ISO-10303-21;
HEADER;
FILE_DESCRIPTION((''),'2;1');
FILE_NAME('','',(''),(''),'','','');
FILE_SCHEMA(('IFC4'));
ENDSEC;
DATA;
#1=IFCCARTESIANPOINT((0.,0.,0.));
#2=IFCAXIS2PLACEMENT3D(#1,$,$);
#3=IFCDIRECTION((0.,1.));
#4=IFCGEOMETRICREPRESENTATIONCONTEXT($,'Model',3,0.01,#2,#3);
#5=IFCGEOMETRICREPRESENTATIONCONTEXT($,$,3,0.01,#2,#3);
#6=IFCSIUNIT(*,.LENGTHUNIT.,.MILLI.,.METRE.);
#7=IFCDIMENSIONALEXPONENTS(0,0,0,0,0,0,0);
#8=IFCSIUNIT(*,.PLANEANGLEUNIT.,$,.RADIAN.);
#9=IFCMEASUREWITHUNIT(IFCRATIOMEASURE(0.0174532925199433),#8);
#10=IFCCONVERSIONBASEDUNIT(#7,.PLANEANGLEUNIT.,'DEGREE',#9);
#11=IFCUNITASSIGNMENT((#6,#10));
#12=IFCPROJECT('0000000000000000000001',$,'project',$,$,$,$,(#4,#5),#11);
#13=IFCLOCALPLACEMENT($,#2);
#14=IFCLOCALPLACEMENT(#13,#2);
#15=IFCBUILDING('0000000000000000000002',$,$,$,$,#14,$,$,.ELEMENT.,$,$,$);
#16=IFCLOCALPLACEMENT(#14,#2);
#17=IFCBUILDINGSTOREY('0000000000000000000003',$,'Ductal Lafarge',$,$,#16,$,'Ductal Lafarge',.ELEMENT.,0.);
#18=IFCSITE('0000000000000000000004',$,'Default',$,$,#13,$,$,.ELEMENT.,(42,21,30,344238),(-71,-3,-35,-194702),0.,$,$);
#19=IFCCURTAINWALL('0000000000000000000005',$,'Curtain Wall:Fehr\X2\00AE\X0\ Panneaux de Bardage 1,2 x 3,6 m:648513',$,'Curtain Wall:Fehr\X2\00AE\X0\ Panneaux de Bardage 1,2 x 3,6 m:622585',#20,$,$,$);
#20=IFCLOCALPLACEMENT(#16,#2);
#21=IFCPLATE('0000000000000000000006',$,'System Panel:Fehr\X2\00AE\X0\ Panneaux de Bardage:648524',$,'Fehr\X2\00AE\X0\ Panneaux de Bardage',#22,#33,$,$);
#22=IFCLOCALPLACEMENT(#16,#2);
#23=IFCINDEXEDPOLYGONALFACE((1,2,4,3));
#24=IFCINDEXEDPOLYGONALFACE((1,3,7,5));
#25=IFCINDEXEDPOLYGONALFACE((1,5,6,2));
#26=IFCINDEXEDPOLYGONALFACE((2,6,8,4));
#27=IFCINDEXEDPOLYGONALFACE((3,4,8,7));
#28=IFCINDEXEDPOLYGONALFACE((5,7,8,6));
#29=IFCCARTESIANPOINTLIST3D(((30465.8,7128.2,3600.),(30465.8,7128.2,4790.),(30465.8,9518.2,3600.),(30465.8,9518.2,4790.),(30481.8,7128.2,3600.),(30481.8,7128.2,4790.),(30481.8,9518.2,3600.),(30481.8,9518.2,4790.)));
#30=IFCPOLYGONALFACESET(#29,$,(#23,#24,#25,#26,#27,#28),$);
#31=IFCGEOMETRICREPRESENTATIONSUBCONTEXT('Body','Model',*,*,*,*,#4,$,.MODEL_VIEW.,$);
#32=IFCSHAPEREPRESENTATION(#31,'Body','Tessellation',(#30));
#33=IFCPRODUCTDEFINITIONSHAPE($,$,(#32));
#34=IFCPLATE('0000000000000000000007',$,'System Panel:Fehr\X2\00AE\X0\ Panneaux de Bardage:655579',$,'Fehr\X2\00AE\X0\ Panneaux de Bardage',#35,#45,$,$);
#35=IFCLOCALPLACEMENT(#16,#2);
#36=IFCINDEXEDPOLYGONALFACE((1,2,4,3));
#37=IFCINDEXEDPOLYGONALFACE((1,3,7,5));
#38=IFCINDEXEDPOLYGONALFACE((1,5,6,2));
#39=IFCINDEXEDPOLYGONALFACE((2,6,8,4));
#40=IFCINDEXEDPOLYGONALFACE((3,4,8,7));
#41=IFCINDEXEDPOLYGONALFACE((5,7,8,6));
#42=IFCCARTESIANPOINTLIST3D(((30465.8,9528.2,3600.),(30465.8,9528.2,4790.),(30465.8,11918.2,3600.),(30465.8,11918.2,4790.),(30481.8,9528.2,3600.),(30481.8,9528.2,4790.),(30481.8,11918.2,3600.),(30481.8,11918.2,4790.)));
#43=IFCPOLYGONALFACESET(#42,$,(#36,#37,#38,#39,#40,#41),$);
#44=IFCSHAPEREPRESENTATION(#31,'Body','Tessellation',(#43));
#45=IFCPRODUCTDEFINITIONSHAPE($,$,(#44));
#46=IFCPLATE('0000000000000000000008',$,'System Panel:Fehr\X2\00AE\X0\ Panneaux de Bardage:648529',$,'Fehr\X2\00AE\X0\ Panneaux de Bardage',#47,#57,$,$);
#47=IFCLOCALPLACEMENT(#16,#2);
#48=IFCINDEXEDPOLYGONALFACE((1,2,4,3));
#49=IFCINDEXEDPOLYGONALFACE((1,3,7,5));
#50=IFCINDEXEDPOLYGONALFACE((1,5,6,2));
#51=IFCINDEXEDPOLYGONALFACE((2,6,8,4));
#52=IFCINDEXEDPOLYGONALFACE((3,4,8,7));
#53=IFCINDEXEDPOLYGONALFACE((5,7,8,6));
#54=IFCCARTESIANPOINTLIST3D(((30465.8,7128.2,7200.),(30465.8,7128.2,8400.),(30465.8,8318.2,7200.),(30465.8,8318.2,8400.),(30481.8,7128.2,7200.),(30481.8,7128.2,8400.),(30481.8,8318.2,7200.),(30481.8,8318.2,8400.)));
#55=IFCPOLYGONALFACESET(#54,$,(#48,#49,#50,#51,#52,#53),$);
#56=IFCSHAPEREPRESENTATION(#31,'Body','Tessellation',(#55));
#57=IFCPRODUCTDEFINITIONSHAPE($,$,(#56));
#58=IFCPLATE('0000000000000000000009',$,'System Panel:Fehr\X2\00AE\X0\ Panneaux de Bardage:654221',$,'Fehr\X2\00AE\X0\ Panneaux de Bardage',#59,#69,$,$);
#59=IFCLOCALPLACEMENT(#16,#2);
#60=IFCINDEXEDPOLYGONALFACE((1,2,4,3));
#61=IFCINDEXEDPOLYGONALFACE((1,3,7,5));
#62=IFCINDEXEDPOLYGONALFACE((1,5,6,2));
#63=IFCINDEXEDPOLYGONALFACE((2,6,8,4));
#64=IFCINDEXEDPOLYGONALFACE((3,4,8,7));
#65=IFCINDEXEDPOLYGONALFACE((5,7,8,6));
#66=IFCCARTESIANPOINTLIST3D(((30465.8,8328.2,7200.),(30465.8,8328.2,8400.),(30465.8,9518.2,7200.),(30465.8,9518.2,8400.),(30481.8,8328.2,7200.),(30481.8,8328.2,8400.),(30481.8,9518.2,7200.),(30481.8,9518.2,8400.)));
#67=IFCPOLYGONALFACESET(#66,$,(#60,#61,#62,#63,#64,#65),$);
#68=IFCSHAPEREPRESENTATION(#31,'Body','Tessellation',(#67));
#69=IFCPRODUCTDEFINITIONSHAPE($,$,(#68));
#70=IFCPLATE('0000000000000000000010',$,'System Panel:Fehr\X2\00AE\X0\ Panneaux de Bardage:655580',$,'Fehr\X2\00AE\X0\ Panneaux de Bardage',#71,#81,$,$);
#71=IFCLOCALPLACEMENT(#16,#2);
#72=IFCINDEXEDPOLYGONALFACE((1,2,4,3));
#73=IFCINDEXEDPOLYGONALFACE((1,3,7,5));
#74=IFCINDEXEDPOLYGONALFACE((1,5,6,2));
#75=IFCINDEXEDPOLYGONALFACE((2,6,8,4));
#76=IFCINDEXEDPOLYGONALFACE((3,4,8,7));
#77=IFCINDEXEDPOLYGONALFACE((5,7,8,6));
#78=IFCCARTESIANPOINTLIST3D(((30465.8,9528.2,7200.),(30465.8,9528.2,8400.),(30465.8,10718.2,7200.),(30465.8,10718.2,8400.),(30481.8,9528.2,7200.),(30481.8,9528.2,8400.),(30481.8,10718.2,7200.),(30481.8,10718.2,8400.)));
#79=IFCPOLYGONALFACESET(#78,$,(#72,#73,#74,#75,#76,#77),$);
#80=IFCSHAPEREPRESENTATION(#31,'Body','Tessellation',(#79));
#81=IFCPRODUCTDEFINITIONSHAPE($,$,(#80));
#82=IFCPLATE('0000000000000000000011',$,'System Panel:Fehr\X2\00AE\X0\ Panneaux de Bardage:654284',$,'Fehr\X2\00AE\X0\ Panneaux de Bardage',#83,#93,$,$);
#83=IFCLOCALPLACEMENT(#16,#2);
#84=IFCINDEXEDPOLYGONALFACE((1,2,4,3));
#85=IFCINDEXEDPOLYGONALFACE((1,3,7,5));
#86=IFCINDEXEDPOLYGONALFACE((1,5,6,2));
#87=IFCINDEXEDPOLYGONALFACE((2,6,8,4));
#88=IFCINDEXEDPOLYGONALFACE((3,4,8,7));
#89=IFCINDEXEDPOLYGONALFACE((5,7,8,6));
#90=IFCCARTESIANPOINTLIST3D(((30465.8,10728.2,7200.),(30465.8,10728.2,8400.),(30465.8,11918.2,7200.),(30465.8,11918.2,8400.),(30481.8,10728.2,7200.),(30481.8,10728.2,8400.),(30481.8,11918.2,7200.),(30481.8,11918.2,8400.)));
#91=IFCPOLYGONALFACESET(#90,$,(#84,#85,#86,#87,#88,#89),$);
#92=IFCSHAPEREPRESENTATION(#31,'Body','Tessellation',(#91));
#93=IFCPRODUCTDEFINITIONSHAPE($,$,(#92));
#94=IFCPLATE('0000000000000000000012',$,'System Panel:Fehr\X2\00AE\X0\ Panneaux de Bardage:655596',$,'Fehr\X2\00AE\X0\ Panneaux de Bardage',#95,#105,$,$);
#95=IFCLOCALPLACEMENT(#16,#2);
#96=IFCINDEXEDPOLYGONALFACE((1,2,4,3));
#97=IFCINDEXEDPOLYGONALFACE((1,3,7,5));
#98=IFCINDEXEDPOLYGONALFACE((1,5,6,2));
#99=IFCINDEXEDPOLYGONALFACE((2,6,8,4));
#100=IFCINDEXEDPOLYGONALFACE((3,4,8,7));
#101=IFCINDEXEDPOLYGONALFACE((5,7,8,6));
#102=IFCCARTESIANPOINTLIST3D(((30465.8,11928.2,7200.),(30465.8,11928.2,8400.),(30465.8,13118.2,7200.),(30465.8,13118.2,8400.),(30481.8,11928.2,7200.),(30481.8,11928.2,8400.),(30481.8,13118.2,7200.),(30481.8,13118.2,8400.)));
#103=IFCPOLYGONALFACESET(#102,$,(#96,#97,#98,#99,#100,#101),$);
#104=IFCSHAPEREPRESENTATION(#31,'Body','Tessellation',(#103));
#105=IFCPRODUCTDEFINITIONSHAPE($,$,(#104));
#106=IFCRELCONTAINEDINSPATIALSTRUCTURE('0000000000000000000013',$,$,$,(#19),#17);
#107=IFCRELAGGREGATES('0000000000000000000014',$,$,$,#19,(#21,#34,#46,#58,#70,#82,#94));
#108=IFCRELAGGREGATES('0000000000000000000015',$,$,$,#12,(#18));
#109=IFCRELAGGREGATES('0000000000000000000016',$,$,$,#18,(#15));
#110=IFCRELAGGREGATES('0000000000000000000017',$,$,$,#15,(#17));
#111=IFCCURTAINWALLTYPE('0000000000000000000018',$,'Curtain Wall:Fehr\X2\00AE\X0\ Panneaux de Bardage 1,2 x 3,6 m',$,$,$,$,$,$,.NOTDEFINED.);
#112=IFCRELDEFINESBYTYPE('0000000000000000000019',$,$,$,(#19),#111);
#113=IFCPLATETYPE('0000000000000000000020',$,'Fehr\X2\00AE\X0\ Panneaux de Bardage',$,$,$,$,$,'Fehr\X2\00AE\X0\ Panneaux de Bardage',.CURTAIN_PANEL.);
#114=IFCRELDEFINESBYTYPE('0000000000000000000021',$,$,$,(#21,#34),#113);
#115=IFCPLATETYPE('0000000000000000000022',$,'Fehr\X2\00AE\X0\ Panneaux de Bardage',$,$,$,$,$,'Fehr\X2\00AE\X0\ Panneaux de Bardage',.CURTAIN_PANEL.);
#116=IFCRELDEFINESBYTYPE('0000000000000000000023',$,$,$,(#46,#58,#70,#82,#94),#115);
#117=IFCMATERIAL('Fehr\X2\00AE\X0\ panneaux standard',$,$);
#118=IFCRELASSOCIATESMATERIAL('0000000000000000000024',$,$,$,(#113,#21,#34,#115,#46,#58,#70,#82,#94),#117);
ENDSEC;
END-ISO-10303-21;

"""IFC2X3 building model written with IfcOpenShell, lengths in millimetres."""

from ifc_helpers import new_model, entity, si_unit, converted_unit, direction, frame, origin, origin_2d_with_axis, place, context, subcontext, project, spatial, rectangle, extrude, source, transform, mapped, material, type_object, type_shapes, element, aggregate, save


model = new_model("IFC2X3")

# Units and contexts
model_context = context("Model", 3, precision=0.01, world=origin(), true_north=direction((0.0, 1.0)))
context_of_model = context(None, 3, precision=0.01, world=origin(), true_north=direction((0.0, 1.0)))
body_context = subcontext(model_context, "Body", "Model", "MODEL_VIEW")
ifc_project = project(units=[si_unit("LENGTHUNIT", "METRE", prefix="MILLI"), converted_unit("PLANEANGLEUNIT", "DEGREE", entity("IfcRatioMeasure", 0.0174532925199433), si_unit("PLANEANGLEUNIT", "RADIAN"), dimensions=[0, 0, 0, 0, 0, 0, 0])], contexts=[model_context, context_of_model])

# Site, building, storey
site_placement = place(None, origin())
site = spatial("IfcSite", under=ifc_project, at=site_placement, Name="Default", CompositionType="ELEMENT", RefLatitude=(42, 21, 30, 344238), RefLongitude=(-71, -3, -35, -194702), RefElevation=0.0)
building_placement = place(site_placement, origin())
building = spatial("IfcBuilding", under=site, at=building_placement, CompositionType="ELEMENT")
storey_placement = place(building_placement, origin())
storey = spatial("IfcBuildingStorey", under=building, at=storey_placement, Name="Ductal Lafarge", LongName="Ductal Lafarge", CompositionType="ELEMENT", Elevation=0.0)

# Curtain wall, plates
curtain_wall_type = type_object("IfcCurtainWallType", Name="Curtain Wall:Fehr® Panneaux de Bardage 1,2 x 3,6 m", PredefinedType="NOTDEFINED")
curtain_wall_placement = place(storey_placement, origin())
curtain_wall = element("IfcCurtainWall", 1, at=curtain_wall_placement, inside=storey, type_object=curtain_wall_type, Name="Curtain Wall:Fehr® Panneaux de Bardage 1,2 x 3,6 m:648513", ObjectType="Curtain Wall:Fehr® Panneaux de Bardage 1,2 x 3,6 m:622585")
ifc_material_1 = material(Name="Fehr® panneaux standard")
plate_type_1 = type_object("IfcPlateType", Name="Fehr® Panneaux de Bardage", ElementType="Fehr® Panneaux de Bardage", PredefinedType="CURTAIN_PANEL", material=ifc_material_1)
shared_shape_1 = source(origin(), body_context, "Body", "SweptSolid", [
    extrude(rectangle(XDim=1190.0, YDim=2390.0, at=origin_2d_with_axis()), frame((0.0, -8.0, 595.0), z_axis=(0.0, 1.0, 0.0), x_axis=(0.0, 0.0, 1.0)), (0.0, 0.0, 1.0), 16.0),
])
type_shapes(plate_type_1, [shared_shape_1])
plate_1_placement = place(curtain_wall_placement, frame((30473.8, 8323.2, 3600.0), z_axis=(0.0, 0.0, 1.0), x_axis=(0.0, 1.0, 0.0)))
plate_1 = element("IfcPlate", 2, at=plate_1_placement, type_object=plate_type_1, material=ifc_material_1, Name="System Panel:Fehr® Panneaux de Bardage:648524", ObjectType="Fehr® Panneaux de Bardage", context=body_context, shape_type="MappedRepresentation", body=[
    mapped(shared_shape_1, transform((0.0, 0.0, 0.0), scale=1.0)),
])
plate_2_placement = place(curtain_wall_placement, frame((30473.8, 10723.2, 3600.0), z_axis=(0.0, 0.0, 1.0), x_axis=(0.0, 1.0, 0.0)))
plate_2 = element("IfcPlate", 3, at=plate_2_placement, type_object=plate_type_1, material=ifc_material_1, Name="System Panel:Fehr® Panneaux de Bardage:655579", ObjectType="Fehr® Panneaux de Bardage", context=body_context, shape_type="MappedRepresentation", body=[
    mapped(shared_shape_1, transform((0.0, 0.0, 0.0), scale=1.0)),
])
plate_type_2 = type_object("IfcPlateType", Name="Fehr® Panneaux de Bardage", ElementType="Fehr® Panneaux de Bardage", PredefinedType="CURTAIN_PANEL", material=ifc_material_1)
shared_shape_2 = source(origin(), body_context, "Body", "SweptSolid", [
    extrude(rectangle(XDim=16.0, YDim=1190.0, at=origin_2d_with_axis()), frame((0.0, 0.0, 0.0), z_axis=(0.0, 0.0, 1.0), x_axis=(0.0, 1.0, 0.0)), (0.0, 0.0, 1.0), 1200.0),
])
type_shapes(plate_type_2, [shared_shape_2])
plate_3_placement = place(curtain_wall_placement, frame((30473.8, 7723.2, 7200.0), z_axis=(0.0, 0.0, 1.0), x_axis=(0.0, 1.0, 0.0)))
plate_3 = element("IfcPlate", 4, at=plate_3_placement, type_object=plate_type_2, material=ifc_material_1, Name="System Panel:Fehr® Panneaux de Bardage:648529", ObjectType="Fehr® Panneaux de Bardage", context=body_context, shape_type="MappedRepresentation", body=[
    mapped(shared_shape_2, transform((0.0, 0.0, 0.0), scale=1.0)),
])
plate_4_placement = place(curtain_wall_placement, frame((30473.8, 8923.2, 7200.0), z_axis=(0.0, 0.0, 1.0), x_axis=(0.0, 1.0, 0.0)))
plate_4 = element("IfcPlate", 5, at=plate_4_placement, type_object=plate_type_2, material=ifc_material_1, Name="System Panel:Fehr® Panneaux de Bardage:654221", ObjectType="Fehr® Panneaux de Bardage", context=body_context, shape_type="MappedRepresentation", body=[
    mapped(shared_shape_2, transform((0.0, 0.0, 0.0), scale=1.0)),
])
plate_5_placement = place(curtain_wall_placement, frame((30473.8, 10123.2, 7200.0), z_axis=(0.0, 0.0, 1.0), x_axis=(0.0, 1.0, 0.0)))
plate_5 = element("IfcPlate", 6, at=plate_5_placement, type_object=plate_type_2, material=ifc_material_1, Name="System Panel:Fehr® Panneaux de Bardage:655580", ObjectType="Fehr® Panneaux de Bardage", context=body_context, shape_type="MappedRepresentation", body=[
    mapped(shared_shape_2, transform((0.0, 0.0, 0.0), scale=1.0)),
])
plate_6_placement = place(curtain_wall_placement, frame((30473.8, 11323.2, 7200.0), z_axis=(0.0, 0.0, 1.0), x_axis=(0.0, 1.0, 0.0)))
plate_6 = element("IfcPlate", 7, at=plate_6_placement, type_object=plate_type_2, material=ifc_material_1, Name="System Panel:Fehr® Panneaux de Bardage:654284", ObjectType="Fehr® Panneaux de Bardage", context=body_context, shape_type="MappedRepresentation", body=[
    mapped(shared_shape_2, transform((0.0, 0.0, 0.0), scale=1.0)),
])
plate_7_placement = place(curtain_wall_placement, frame((30473.8, 12523.2, 7200.0), z_axis=(0.0, 0.0, 1.0), x_axis=(0.0, 1.0, 0.0)))
plate_7 = element("IfcPlate", 8, at=plate_7_placement, type_object=plate_type_2, material=ifc_material_1, Name="System Panel:Fehr® Panneaux de Bardage:655596", ObjectType="Fehr® Panneaux de Bardage", context=body_context, shape_type="MappedRepresentation", body=[
    mapped(shared_shape_2, transform((0.0, 0.0, 0.0), scale=1.0)),
])
aggregate(curtain_wall, [plate_1, plate_2, plate_3, plate_4, plate_5, plate_6, plate_7])

save(model, "model.ifc")
